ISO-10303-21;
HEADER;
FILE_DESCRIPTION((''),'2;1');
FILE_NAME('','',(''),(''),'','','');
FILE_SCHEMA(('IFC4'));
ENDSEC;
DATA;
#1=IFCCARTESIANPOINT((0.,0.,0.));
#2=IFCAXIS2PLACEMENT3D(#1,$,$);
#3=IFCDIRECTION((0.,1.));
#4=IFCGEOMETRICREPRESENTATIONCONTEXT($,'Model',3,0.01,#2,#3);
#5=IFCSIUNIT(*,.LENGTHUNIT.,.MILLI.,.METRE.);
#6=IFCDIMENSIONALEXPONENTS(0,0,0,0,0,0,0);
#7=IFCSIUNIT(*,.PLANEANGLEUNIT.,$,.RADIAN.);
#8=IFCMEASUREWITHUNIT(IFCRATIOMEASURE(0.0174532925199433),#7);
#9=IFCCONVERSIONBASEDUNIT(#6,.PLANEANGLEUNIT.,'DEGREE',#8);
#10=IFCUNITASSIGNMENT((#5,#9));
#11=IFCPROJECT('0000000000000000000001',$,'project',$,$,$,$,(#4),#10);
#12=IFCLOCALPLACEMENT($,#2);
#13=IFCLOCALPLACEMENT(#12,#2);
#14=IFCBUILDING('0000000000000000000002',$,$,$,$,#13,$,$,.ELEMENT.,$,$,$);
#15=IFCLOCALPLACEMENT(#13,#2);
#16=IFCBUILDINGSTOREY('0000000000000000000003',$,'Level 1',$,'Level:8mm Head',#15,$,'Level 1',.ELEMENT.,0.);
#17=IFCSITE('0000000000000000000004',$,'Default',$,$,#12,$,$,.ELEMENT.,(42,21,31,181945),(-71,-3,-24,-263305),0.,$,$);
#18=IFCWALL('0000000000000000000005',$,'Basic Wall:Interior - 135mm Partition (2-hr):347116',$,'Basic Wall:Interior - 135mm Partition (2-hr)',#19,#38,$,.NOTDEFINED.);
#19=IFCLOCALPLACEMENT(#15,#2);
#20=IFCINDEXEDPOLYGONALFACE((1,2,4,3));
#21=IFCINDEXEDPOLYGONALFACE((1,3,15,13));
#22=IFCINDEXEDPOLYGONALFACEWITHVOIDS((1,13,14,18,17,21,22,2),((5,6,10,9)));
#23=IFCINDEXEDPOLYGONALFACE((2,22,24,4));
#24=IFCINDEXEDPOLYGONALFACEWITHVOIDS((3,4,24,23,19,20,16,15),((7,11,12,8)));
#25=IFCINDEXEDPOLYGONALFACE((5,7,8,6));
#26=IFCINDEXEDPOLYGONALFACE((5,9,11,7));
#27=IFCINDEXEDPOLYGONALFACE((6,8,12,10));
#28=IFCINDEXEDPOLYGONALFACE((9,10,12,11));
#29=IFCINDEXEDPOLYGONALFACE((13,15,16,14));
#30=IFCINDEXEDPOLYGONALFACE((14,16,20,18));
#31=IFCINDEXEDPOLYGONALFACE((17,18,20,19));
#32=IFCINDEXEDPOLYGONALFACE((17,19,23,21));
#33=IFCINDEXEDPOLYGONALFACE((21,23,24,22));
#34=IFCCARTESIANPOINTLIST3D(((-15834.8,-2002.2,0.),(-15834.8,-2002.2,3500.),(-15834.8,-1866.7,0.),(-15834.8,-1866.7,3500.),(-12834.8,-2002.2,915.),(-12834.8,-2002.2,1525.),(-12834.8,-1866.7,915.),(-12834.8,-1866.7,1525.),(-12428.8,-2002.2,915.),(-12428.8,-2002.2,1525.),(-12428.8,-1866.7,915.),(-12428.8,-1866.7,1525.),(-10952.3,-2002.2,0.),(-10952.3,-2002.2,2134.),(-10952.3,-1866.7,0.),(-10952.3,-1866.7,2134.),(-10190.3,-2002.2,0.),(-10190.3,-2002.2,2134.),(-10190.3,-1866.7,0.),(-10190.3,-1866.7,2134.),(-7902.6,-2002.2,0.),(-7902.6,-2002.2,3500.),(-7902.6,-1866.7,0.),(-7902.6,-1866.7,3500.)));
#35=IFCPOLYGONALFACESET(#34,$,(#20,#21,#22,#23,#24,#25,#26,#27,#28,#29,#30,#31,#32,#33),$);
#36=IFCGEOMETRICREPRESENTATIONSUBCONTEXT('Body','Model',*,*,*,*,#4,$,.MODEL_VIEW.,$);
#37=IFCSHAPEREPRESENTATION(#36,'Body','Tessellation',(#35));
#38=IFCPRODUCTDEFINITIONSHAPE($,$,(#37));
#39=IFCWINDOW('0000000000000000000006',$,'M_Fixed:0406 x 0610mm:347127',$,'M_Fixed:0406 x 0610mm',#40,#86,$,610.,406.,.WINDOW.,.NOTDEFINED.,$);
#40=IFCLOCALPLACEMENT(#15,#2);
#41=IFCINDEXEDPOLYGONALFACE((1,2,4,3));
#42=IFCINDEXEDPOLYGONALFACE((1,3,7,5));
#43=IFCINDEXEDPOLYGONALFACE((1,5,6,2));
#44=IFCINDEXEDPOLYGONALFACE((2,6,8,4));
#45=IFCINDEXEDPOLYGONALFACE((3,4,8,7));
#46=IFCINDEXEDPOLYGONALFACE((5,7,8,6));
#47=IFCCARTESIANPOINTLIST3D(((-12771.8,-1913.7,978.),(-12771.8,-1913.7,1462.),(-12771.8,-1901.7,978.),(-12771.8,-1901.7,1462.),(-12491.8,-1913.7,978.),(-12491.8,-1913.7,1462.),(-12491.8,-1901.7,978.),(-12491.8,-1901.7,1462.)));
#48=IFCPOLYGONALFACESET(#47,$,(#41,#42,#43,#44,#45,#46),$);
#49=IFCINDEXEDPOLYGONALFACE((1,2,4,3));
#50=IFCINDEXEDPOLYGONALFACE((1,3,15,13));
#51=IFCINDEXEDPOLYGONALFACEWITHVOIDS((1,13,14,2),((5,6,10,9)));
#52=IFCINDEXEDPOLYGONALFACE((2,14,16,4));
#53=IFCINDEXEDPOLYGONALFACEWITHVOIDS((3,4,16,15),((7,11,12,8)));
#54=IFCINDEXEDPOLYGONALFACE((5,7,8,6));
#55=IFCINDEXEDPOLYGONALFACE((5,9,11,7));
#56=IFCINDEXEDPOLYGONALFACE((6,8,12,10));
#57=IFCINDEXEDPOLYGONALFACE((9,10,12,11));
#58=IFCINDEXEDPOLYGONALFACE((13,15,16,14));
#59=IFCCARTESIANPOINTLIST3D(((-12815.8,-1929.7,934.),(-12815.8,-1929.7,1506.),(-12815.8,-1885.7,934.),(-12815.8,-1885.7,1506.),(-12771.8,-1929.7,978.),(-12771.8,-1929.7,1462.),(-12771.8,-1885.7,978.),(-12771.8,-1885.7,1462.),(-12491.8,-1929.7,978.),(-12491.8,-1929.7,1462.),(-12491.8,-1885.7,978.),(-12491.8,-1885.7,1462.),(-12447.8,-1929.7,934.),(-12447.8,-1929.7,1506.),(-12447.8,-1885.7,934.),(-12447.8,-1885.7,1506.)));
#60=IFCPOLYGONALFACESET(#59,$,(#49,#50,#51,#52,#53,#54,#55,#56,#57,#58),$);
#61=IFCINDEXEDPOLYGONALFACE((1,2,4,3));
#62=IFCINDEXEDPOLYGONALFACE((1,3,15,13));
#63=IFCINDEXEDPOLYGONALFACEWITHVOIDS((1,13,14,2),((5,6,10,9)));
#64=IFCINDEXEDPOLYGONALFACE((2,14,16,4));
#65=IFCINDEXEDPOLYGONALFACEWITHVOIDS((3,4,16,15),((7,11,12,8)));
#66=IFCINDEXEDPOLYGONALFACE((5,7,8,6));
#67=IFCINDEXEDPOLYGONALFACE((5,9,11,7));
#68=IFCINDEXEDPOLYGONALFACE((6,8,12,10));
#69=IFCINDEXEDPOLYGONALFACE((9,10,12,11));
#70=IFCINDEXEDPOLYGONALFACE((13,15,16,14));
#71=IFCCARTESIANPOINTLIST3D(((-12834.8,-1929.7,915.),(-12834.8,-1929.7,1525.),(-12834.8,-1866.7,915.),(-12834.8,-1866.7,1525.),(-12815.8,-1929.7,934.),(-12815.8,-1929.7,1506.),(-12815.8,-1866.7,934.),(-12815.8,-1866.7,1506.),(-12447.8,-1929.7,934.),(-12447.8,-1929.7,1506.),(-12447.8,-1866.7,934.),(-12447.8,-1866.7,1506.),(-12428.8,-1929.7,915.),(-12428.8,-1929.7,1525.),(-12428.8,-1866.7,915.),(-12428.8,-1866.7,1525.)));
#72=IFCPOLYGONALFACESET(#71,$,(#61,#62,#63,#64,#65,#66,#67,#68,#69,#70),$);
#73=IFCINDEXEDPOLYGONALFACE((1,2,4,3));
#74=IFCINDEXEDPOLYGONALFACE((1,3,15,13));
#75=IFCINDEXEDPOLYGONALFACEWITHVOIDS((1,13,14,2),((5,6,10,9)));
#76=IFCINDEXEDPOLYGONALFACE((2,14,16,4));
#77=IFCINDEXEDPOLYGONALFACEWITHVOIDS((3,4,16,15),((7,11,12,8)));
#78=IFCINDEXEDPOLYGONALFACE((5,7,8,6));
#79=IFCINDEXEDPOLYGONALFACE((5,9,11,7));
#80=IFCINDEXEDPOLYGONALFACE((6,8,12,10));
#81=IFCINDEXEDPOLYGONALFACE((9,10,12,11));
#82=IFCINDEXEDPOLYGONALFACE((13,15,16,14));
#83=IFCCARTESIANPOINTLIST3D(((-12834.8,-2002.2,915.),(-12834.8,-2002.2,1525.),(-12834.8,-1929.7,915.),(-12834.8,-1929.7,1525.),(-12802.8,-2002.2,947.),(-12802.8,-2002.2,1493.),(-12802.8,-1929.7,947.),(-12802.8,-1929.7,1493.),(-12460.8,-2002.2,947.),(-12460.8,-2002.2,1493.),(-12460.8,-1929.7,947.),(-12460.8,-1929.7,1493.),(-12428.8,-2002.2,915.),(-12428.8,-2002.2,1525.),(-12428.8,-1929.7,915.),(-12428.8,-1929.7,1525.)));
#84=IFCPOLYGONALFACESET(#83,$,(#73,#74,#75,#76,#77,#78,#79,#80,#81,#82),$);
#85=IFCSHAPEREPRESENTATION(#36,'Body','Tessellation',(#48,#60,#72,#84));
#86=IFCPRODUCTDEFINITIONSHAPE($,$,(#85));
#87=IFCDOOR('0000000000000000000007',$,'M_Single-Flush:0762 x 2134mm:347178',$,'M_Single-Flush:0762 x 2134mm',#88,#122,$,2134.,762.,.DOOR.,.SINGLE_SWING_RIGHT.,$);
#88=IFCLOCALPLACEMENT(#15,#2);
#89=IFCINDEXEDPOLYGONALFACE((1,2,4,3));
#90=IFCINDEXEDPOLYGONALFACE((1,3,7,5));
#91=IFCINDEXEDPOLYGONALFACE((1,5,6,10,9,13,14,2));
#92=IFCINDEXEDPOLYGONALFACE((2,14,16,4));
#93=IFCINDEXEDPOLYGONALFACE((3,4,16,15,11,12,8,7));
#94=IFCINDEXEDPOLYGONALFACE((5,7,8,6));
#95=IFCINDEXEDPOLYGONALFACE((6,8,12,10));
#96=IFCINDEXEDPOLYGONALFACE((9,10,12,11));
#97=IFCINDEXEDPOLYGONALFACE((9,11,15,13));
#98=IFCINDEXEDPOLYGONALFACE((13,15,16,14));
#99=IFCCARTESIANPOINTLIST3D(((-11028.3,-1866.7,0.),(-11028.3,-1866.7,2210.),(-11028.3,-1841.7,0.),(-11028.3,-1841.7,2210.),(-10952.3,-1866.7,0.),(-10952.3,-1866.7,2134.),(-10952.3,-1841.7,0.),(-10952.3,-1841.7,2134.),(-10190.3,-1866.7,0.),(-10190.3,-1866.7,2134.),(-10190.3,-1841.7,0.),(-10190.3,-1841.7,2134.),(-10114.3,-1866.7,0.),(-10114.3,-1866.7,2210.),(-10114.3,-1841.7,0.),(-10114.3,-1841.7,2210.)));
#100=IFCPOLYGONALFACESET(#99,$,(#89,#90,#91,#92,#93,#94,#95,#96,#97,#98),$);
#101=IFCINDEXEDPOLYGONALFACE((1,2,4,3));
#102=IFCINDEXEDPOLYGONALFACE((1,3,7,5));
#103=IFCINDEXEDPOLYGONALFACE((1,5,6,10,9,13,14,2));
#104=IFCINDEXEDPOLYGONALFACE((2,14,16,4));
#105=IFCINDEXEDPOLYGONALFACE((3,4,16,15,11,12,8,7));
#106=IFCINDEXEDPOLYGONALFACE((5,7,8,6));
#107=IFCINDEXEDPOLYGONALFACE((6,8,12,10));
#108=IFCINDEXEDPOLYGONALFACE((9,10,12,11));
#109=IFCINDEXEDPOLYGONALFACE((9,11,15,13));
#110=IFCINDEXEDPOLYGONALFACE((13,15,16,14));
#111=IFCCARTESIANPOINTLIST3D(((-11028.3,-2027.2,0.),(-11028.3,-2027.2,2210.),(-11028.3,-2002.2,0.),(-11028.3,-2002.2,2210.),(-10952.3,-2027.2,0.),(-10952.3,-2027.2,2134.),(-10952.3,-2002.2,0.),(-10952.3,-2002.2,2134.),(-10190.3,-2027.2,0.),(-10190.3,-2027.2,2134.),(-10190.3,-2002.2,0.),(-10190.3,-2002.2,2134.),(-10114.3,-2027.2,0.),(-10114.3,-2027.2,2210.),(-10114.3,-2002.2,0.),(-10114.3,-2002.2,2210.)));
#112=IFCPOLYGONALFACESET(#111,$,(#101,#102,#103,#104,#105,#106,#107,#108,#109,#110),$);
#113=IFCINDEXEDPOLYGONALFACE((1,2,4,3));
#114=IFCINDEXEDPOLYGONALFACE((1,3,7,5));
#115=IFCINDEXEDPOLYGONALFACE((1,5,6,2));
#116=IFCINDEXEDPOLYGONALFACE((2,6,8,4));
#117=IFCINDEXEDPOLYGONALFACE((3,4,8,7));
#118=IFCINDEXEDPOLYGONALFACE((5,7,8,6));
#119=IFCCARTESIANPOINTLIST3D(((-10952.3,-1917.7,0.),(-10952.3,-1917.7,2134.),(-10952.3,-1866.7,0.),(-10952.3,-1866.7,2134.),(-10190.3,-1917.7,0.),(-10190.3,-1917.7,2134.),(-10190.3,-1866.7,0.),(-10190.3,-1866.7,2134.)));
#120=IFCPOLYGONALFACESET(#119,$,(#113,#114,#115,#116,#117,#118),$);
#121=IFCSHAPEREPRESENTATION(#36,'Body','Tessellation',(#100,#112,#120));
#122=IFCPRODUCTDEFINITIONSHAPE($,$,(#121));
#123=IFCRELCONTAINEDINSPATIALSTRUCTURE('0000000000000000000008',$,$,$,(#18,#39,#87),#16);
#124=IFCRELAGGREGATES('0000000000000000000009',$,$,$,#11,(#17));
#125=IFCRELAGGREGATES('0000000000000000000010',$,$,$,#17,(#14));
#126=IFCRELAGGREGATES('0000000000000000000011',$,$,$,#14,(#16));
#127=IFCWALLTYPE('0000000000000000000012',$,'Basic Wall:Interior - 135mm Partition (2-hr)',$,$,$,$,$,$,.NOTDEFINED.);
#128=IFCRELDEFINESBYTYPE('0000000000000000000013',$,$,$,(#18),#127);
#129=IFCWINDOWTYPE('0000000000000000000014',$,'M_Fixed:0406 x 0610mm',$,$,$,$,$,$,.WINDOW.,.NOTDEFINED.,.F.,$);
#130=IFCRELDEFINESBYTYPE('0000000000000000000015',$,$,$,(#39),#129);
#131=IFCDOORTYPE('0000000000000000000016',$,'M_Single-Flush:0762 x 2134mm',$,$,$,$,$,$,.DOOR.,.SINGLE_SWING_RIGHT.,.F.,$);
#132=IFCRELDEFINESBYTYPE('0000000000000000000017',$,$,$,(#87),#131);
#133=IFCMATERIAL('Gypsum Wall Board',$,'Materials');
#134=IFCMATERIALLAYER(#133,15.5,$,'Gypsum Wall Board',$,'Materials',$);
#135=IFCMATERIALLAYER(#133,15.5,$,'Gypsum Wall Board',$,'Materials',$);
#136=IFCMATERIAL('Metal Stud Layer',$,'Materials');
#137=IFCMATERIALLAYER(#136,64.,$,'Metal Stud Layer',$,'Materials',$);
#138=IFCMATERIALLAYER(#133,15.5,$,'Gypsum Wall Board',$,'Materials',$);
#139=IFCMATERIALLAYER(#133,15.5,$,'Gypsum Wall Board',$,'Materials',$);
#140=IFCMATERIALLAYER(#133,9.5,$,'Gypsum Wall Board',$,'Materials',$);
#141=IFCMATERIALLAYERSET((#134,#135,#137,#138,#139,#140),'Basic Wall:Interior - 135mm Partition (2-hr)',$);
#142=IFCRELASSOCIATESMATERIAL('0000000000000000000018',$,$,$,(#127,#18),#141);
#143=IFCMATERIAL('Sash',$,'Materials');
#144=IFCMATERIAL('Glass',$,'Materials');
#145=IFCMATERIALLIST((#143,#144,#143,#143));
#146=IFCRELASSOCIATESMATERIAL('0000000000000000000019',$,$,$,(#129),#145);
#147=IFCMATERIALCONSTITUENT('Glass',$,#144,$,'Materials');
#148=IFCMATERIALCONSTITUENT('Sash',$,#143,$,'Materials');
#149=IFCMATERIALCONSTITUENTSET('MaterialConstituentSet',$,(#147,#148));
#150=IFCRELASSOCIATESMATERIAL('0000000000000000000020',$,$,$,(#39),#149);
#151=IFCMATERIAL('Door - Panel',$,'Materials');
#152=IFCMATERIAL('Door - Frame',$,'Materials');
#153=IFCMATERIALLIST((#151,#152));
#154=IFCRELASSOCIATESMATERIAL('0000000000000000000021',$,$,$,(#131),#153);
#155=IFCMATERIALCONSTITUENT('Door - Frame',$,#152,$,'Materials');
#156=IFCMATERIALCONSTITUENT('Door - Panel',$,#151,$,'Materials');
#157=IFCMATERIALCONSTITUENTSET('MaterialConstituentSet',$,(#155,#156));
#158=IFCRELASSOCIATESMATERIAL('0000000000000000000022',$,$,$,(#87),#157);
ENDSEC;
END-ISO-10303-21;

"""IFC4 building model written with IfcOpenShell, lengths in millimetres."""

from ifc_helpers import new_model, entity, si_unit, converted_unit, direction, frame, frame_2d, origin, origin_2d_with_axis, place, context, subcontext, project, spatial, polyline, rectangle, outline, extrude, source, transform, mapped, material, material_list, layer, layer_set, layer_usage, constituent, constituent_set, type_object, type_shapes, element, fill, save


model = new_model("IFC4")

# Units and contexts
model_context = context("Model", 3, precision=0.01, world=origin(), true_north=direction((0.0, 1.0)))
body_context = subcontext(model_context, "Body", "Model", "MODEL_VIEW")
ifc_project = project(units=[si_unit("LENGTHUNIT", "METRE", prefix="MILLI"), converted_unit("PLANEANGLEUNIT", "DEGREE", entity("IfcRatioMeasure", 0.0174532925199433), si_unit("PLANEANGLEUNIT", "RADIAN"), dimensions=[0, 0, 0, 0, 0, 0, 0])], contexts=[model_context])

# Site, building, storey
site_placement = place(None, origin())
site = spatial("IfcSite", under=ifc_project, at=site_placement, Name="Default", CompositionType="ELEMENT", RefLatitude=(42, 21, 31, 181945), RefLongitude=(-71, -3, -24, -263305), RefElevation=0.0)
building_placement = place(site_placement, origin())
building = spatial("IfcBuilding", under=site, at=building_placement, CompositionType="ELEMENT")
storey_placement = place(building_placement, origin())
storey = spatial("IfcBuildingStorey", under=building, at=storey_placement, Name="Level 1", ObjectType="Level:8mm Head", LongName="Level 1", CompositionType="ELEMENT", Elevation=0.0)

# Shared definitions
ifc_material_1 = material(Name="Metal Stud Layer", Category="Materials")
ifc_material_2 = material(Name="Gypsum Wall Board", Category="Materials")
ifc_material_3 = material(Name="Door - Frame", Category="Materials")
ifc_material_4 = material(Name="Door - Panel", Category="Materials")
ifc_material_5 = material(Name="Glass", Category="Materials")
ifc_material_6 = material(Name="Sash", Category="Materials")

# Shared definitions
ifc_layer_1 = layer(ifc_material_2, 15.5, Name="Gypsum Wall Board", Category="Materials")
ifc_layer_2 = layer(ifc_material_2, 15.5, Name="Gypsum Wall Board", Category="Materials")
ifc_layer_3 = layer(ifc_material_1, 64.0, Name="Metal Stud Layer", Category="Materials")
ifc_layer_4 = layer(ifc_material_2, 15.5, Name="Gypsum Wall Board", Category="Materials")
ifc_layer_5 = layer(ifc_material_2, 15.5, Name="Gypsum Wall Board", Category="Materials")
ifc_layer_6 = layer(ifc_material_2, 9.5, Name="Gypsum Wall Board", Category="Materials")
ifc_layer_set_1 = layer_set([ifc_layer_1, ifc_layer_2, ifc_layer_3, ifc_layer_4, ifc_layer_5, ifc_layer_6], Name="Basic Wall:Interior - 135mm Partition (2-hr)")
wall_type_1 = type_object("IfcWallType", Name="Basic Wall:Interior - 135mm Partition (2-hr)", PredefinedType="NOTDEFINED", material=ifc_layer_set_1)

# Wall, openings, window, door
ifc_layer_usage_1 = layer_usage(ifc_layer_set_1, "AXIS2", "NEGATIVE", 67.8)
wall_1_placement = place(storey_placement, frame((-7902.6, -1934.5, 0.0), z_axis=(0.0, 0.0, 1.0), x_axis=(-1.0, 0.0, 0.0)))
wall_1 = element("IfcWall", 1, at=wall_1_placement, inside=storey, type_object=wall_type_1, material=ifc_layer_usage_1, Name="Basic Wall:Interior - 135mm Partition (2-hr):347116", ObjectType="Basic Wall:Interior - 135mm Partition (2-hr)", PredefinedType="NOTDEFINED", context=body_context, shape_type="SweptSolid", body=[
    extrude(rectangle(XDim=7932.3, YDim=135.5, at=frame_2d((3966.1, 0.0), x_axis=(-1.0, 0.0))), origin(), (0.0, 0.0, 1.0), 3500.0),
])
opening_1_placement = place(wall_1_placement, frame((3049.8, 67.7, 0.0)))
opening_1 = element("IfcOpeningElement", 2, at=opening_1_placement, cuts=wall_1, ObjectType="Opening", PredefinedType="OPENING", context=body_context, shape_type="SweptSolid", body=[
    extrude(rectangle(XDim=762.0, YDim=2134.0, at=frame_2d((1067.0, 381.0), x_axis=(0.0, 1.0))), frame((0.0, 0.0, 0.0), z_axis=(0.0, -1.0, 0.0), x_axis=(0.0, 0.0, 1.0)), (0.0, 0.0, 1.0), 135.5),
])
opening_2_placement = place(wall_1_placement, frame((4932.3, 67.7, 915.0)))
opening_2 = element("IfcOpeningElement", 3, at=opening_2_placement, cuts=wall_1, ObjectType="Opening", PredefinedType="OPENING", context=body_context, shape_type="SweptSolid", body=[
    extrude(rectangle(XDim=610.0, YDim=406.0, at=frame_2d((305.0, 203.0), x_axis=(1.0, 0.0))), frame((0.0, 0.0, 0.0), z_axis=(0.0, -1.0, 0.0), x_axis=(0.0, 0.0, 1.0)), (0.0, 0.0, 1.0), 135.5),
])
ifc_constituent_1 = constituent(ifc_material_5, Name="Glass", Category="Materials")
ifc_constituent_2 = constituent(ifc_material_6, Name="Sash", Category="Materials")
ifc_constituent_set_1 = constituent_set(constituents=[ifc_constituent_1, ifc_constituent_2], Name="MaterialConstituentSet")
ifc_material_list_1 = material_list([ifc_material_6, ifc_material_5, ifc_material_6, ifc_material_6])
window_type_1 = type_object("IfcWindowType", Name="M_Fixed:0406 x 0610mm", ParameterTakesPrecedence=False, PartitioningType="NOTDEFINED", PredefinedType="WINDOW", material=ifc_material_list_1)
shared_shape_1 = source(origin(), body_context, "Body", "SweptSolid", [
    extrude(rectangle(XDim=12.0, YDim=280.0, at=origin_2d_with_axis()), frame((203.0, 94.5, 63.0), z_axis=(0.0, 0.0, 1.0), x_axis=(0.0, -1.0, 0.0)), (0.0, 0.0, 1.0), 484.0),
    extrude(outline(polyline([(-184.0, -286.0), (184.0, -286.0), (184.0, 286.0), (-184.0, 286.0), (-184.0, -286.0)]), holes=[polyline([(-140.0, -242.0), (-140.0, 242.0), (140.0, 242.0), (140.0, -242.0), (-140.0, -242.0)])]), frame((203.0, 72.5, 305.0), z_axis=(0.0, 1.0, 0.0), x_axis=(1.0, 0.0, 0.0)), (0.0, 0.0, 1.0), 44.0),
    extrude(outline(polyline([(-203.0, -305.0), (203.0, -305.0), (203.0, 305.0), (-203.0, 305.0), (-203.0, -305.0)]), holes=[polyline([(-184.0, -286.0), (-184.0, 286.0), (184.0, 286.0), (184.0, -286.0), (-184.0, -286.0)])]), frame((203.0, 72.5, 305.0), z_axis=(0.0, 1.0, 0.0), x_axis=(1.0, 0.0, 0.0)), (0.0, 0.0, 1.0), 63.0),
    extrude(outline(polyline([(-203.0, -305.0), (203.0, -305.0), (203.0, 305.0), (-203.0, 305.0), (-203.0, -305.0)]), holes=[polyline([(-171.0, -273.0), (-171.0, 273.0), (171.0, 273.0), (171.0, -273.0), (-171.0, -273.0)])]), frame((203.0, 0.0, 305.0), z_axis=(0.0, 1.0, 0.0), x_axis=(1.0, 0.0, 0.0)), (0.0, 0.0, 1.0), 72.5),
])
type_shapes(window_type_1, [shared_shape_1])
window_1_placement = place(opening_2_placement, frame((0.0, 0.0, 0.0), z_axis=(0.0, 0.0, 1.0), x_axis=(-1.0, 0.0, 0.0)))
window_1 = element("IfcWindow", 4, at=window_1_placement, inside=storey, type_object=window_type_1, material=ifc_constituent_set_1, Name="M_Fixed:0406 x 0610mm:347127", ObjectType="M_Fixed:0406 x 0610mm", OverallHeight=610.0, OverallWidth=406.0, PartitioningType="NOTDEFINED", PredefinedType="WINDOW", context=body_context, shape_type="MappedRepresentation", body=[
    mapped(shared_shape_1, transform((0.0, 0.0, 0.0), scale=1.0)),
])
fill(opening_2, window_1)
ifc_constituent_3 = constituent(ifc_material_3, Name="Door - Frame", Category="Materials")
ifc_constituent_4 = constituent(ifc_material_4, Name="Door - Panel", Category="Materials")
ifc_constituent_set_2 = constituent_set(constituents=[ifc_constituent_3, ifc_constituent_4], Name="MaterialConstituentSet")
ifc_material_list_2 = material_list([ifc_material_4, ifc_material_3])
door_type_1 = type_object("IfcDoorType", Name="M_Single-Flush:0762 x 2134mm", OperationType="SINGLE_SWING_RIGHT", ParameterTakesPrecedence=False, PredefinedType="DOOR", material=ifc_material_list_2)
shared_shape_2 = source(origin(), body_context, "Body", "SweptSolid", [
    extrude(outline(polyline([(-457.0, -1124.0), (457.0, -1124.0), (457.0, 1086.0), (381.0, 1086.0), (381.0, -1048.0), (-381.0, -1048.0), (-381.0, 1086.0), (-457.0, 1086.0), (-457.0, -1124.0)])), frame((381.0, 135.5, 1086.0), z_axis=(0.0, 1.0, 0.0), x_axis=(1.0, 0.0, 0.0)), (0.0, 0.0, 1.0), 25.0),
    extrude(outline(polyline([(-1124.0, -457.0), (1086.0, -457.0), (1086.0, -381.0), (-1048.0, -381.0), (-1048.0, 381.0), (1086.0, 381.0), (1086.0, 457.0), (-1124.0, 457.0), (-1124.0, -457.0)])), frame((381.0, -25.0, 1086.0), z_axis=(0.0, 1.0, 0.0), x_axis=(0.0, 0.0, -1.0)), (0.0, 0.0, 1.0), 25.0),
    extrude(rectangle(XDim=51.0, YDim=762.0, at=frame_2d((0.0, 0.0), x_axis=(1.0, 0.0))), frame((381.0, 110.0, 0.0), z_axis=(0.0, 0.0, 1.0), x_axis=(0.0, 1.0, 0.0)), (0.0, 0.0, 1.0), 2134.0),
])
type_shapes(door_type_1, [shared_shape_2])
door_1_placement = place(opening_1_placement, frame((0.0, 0.0, 0.0), z_axis=(0.0, 0.0, 1.0), x_axis=(-1.0, 0.0, 0.0)))
door_1 = element("IfcDoor", 5, at=door_1_placement, inside=storey, type_object=door_type_1, material=ifc_constituent_set_2, Name="M_Single-Flush:0762 x 2134mm:347178", ObjectType="M_Single-Flush:0762 x 2134mm", OperationType="SINGLE_SWING_RIGHT", OverallHeight=2134.0, OverallWidth=762.0, PredefinedType="DOOR", context=body_context, shape_type="MappedRepresentation", body=[
    mapped(shared_shape_2, transform((0.0, 0.0, 0.0), scale=1.0)),
])
fill(opening_1, door_1)

save(model, "model.ifc")
